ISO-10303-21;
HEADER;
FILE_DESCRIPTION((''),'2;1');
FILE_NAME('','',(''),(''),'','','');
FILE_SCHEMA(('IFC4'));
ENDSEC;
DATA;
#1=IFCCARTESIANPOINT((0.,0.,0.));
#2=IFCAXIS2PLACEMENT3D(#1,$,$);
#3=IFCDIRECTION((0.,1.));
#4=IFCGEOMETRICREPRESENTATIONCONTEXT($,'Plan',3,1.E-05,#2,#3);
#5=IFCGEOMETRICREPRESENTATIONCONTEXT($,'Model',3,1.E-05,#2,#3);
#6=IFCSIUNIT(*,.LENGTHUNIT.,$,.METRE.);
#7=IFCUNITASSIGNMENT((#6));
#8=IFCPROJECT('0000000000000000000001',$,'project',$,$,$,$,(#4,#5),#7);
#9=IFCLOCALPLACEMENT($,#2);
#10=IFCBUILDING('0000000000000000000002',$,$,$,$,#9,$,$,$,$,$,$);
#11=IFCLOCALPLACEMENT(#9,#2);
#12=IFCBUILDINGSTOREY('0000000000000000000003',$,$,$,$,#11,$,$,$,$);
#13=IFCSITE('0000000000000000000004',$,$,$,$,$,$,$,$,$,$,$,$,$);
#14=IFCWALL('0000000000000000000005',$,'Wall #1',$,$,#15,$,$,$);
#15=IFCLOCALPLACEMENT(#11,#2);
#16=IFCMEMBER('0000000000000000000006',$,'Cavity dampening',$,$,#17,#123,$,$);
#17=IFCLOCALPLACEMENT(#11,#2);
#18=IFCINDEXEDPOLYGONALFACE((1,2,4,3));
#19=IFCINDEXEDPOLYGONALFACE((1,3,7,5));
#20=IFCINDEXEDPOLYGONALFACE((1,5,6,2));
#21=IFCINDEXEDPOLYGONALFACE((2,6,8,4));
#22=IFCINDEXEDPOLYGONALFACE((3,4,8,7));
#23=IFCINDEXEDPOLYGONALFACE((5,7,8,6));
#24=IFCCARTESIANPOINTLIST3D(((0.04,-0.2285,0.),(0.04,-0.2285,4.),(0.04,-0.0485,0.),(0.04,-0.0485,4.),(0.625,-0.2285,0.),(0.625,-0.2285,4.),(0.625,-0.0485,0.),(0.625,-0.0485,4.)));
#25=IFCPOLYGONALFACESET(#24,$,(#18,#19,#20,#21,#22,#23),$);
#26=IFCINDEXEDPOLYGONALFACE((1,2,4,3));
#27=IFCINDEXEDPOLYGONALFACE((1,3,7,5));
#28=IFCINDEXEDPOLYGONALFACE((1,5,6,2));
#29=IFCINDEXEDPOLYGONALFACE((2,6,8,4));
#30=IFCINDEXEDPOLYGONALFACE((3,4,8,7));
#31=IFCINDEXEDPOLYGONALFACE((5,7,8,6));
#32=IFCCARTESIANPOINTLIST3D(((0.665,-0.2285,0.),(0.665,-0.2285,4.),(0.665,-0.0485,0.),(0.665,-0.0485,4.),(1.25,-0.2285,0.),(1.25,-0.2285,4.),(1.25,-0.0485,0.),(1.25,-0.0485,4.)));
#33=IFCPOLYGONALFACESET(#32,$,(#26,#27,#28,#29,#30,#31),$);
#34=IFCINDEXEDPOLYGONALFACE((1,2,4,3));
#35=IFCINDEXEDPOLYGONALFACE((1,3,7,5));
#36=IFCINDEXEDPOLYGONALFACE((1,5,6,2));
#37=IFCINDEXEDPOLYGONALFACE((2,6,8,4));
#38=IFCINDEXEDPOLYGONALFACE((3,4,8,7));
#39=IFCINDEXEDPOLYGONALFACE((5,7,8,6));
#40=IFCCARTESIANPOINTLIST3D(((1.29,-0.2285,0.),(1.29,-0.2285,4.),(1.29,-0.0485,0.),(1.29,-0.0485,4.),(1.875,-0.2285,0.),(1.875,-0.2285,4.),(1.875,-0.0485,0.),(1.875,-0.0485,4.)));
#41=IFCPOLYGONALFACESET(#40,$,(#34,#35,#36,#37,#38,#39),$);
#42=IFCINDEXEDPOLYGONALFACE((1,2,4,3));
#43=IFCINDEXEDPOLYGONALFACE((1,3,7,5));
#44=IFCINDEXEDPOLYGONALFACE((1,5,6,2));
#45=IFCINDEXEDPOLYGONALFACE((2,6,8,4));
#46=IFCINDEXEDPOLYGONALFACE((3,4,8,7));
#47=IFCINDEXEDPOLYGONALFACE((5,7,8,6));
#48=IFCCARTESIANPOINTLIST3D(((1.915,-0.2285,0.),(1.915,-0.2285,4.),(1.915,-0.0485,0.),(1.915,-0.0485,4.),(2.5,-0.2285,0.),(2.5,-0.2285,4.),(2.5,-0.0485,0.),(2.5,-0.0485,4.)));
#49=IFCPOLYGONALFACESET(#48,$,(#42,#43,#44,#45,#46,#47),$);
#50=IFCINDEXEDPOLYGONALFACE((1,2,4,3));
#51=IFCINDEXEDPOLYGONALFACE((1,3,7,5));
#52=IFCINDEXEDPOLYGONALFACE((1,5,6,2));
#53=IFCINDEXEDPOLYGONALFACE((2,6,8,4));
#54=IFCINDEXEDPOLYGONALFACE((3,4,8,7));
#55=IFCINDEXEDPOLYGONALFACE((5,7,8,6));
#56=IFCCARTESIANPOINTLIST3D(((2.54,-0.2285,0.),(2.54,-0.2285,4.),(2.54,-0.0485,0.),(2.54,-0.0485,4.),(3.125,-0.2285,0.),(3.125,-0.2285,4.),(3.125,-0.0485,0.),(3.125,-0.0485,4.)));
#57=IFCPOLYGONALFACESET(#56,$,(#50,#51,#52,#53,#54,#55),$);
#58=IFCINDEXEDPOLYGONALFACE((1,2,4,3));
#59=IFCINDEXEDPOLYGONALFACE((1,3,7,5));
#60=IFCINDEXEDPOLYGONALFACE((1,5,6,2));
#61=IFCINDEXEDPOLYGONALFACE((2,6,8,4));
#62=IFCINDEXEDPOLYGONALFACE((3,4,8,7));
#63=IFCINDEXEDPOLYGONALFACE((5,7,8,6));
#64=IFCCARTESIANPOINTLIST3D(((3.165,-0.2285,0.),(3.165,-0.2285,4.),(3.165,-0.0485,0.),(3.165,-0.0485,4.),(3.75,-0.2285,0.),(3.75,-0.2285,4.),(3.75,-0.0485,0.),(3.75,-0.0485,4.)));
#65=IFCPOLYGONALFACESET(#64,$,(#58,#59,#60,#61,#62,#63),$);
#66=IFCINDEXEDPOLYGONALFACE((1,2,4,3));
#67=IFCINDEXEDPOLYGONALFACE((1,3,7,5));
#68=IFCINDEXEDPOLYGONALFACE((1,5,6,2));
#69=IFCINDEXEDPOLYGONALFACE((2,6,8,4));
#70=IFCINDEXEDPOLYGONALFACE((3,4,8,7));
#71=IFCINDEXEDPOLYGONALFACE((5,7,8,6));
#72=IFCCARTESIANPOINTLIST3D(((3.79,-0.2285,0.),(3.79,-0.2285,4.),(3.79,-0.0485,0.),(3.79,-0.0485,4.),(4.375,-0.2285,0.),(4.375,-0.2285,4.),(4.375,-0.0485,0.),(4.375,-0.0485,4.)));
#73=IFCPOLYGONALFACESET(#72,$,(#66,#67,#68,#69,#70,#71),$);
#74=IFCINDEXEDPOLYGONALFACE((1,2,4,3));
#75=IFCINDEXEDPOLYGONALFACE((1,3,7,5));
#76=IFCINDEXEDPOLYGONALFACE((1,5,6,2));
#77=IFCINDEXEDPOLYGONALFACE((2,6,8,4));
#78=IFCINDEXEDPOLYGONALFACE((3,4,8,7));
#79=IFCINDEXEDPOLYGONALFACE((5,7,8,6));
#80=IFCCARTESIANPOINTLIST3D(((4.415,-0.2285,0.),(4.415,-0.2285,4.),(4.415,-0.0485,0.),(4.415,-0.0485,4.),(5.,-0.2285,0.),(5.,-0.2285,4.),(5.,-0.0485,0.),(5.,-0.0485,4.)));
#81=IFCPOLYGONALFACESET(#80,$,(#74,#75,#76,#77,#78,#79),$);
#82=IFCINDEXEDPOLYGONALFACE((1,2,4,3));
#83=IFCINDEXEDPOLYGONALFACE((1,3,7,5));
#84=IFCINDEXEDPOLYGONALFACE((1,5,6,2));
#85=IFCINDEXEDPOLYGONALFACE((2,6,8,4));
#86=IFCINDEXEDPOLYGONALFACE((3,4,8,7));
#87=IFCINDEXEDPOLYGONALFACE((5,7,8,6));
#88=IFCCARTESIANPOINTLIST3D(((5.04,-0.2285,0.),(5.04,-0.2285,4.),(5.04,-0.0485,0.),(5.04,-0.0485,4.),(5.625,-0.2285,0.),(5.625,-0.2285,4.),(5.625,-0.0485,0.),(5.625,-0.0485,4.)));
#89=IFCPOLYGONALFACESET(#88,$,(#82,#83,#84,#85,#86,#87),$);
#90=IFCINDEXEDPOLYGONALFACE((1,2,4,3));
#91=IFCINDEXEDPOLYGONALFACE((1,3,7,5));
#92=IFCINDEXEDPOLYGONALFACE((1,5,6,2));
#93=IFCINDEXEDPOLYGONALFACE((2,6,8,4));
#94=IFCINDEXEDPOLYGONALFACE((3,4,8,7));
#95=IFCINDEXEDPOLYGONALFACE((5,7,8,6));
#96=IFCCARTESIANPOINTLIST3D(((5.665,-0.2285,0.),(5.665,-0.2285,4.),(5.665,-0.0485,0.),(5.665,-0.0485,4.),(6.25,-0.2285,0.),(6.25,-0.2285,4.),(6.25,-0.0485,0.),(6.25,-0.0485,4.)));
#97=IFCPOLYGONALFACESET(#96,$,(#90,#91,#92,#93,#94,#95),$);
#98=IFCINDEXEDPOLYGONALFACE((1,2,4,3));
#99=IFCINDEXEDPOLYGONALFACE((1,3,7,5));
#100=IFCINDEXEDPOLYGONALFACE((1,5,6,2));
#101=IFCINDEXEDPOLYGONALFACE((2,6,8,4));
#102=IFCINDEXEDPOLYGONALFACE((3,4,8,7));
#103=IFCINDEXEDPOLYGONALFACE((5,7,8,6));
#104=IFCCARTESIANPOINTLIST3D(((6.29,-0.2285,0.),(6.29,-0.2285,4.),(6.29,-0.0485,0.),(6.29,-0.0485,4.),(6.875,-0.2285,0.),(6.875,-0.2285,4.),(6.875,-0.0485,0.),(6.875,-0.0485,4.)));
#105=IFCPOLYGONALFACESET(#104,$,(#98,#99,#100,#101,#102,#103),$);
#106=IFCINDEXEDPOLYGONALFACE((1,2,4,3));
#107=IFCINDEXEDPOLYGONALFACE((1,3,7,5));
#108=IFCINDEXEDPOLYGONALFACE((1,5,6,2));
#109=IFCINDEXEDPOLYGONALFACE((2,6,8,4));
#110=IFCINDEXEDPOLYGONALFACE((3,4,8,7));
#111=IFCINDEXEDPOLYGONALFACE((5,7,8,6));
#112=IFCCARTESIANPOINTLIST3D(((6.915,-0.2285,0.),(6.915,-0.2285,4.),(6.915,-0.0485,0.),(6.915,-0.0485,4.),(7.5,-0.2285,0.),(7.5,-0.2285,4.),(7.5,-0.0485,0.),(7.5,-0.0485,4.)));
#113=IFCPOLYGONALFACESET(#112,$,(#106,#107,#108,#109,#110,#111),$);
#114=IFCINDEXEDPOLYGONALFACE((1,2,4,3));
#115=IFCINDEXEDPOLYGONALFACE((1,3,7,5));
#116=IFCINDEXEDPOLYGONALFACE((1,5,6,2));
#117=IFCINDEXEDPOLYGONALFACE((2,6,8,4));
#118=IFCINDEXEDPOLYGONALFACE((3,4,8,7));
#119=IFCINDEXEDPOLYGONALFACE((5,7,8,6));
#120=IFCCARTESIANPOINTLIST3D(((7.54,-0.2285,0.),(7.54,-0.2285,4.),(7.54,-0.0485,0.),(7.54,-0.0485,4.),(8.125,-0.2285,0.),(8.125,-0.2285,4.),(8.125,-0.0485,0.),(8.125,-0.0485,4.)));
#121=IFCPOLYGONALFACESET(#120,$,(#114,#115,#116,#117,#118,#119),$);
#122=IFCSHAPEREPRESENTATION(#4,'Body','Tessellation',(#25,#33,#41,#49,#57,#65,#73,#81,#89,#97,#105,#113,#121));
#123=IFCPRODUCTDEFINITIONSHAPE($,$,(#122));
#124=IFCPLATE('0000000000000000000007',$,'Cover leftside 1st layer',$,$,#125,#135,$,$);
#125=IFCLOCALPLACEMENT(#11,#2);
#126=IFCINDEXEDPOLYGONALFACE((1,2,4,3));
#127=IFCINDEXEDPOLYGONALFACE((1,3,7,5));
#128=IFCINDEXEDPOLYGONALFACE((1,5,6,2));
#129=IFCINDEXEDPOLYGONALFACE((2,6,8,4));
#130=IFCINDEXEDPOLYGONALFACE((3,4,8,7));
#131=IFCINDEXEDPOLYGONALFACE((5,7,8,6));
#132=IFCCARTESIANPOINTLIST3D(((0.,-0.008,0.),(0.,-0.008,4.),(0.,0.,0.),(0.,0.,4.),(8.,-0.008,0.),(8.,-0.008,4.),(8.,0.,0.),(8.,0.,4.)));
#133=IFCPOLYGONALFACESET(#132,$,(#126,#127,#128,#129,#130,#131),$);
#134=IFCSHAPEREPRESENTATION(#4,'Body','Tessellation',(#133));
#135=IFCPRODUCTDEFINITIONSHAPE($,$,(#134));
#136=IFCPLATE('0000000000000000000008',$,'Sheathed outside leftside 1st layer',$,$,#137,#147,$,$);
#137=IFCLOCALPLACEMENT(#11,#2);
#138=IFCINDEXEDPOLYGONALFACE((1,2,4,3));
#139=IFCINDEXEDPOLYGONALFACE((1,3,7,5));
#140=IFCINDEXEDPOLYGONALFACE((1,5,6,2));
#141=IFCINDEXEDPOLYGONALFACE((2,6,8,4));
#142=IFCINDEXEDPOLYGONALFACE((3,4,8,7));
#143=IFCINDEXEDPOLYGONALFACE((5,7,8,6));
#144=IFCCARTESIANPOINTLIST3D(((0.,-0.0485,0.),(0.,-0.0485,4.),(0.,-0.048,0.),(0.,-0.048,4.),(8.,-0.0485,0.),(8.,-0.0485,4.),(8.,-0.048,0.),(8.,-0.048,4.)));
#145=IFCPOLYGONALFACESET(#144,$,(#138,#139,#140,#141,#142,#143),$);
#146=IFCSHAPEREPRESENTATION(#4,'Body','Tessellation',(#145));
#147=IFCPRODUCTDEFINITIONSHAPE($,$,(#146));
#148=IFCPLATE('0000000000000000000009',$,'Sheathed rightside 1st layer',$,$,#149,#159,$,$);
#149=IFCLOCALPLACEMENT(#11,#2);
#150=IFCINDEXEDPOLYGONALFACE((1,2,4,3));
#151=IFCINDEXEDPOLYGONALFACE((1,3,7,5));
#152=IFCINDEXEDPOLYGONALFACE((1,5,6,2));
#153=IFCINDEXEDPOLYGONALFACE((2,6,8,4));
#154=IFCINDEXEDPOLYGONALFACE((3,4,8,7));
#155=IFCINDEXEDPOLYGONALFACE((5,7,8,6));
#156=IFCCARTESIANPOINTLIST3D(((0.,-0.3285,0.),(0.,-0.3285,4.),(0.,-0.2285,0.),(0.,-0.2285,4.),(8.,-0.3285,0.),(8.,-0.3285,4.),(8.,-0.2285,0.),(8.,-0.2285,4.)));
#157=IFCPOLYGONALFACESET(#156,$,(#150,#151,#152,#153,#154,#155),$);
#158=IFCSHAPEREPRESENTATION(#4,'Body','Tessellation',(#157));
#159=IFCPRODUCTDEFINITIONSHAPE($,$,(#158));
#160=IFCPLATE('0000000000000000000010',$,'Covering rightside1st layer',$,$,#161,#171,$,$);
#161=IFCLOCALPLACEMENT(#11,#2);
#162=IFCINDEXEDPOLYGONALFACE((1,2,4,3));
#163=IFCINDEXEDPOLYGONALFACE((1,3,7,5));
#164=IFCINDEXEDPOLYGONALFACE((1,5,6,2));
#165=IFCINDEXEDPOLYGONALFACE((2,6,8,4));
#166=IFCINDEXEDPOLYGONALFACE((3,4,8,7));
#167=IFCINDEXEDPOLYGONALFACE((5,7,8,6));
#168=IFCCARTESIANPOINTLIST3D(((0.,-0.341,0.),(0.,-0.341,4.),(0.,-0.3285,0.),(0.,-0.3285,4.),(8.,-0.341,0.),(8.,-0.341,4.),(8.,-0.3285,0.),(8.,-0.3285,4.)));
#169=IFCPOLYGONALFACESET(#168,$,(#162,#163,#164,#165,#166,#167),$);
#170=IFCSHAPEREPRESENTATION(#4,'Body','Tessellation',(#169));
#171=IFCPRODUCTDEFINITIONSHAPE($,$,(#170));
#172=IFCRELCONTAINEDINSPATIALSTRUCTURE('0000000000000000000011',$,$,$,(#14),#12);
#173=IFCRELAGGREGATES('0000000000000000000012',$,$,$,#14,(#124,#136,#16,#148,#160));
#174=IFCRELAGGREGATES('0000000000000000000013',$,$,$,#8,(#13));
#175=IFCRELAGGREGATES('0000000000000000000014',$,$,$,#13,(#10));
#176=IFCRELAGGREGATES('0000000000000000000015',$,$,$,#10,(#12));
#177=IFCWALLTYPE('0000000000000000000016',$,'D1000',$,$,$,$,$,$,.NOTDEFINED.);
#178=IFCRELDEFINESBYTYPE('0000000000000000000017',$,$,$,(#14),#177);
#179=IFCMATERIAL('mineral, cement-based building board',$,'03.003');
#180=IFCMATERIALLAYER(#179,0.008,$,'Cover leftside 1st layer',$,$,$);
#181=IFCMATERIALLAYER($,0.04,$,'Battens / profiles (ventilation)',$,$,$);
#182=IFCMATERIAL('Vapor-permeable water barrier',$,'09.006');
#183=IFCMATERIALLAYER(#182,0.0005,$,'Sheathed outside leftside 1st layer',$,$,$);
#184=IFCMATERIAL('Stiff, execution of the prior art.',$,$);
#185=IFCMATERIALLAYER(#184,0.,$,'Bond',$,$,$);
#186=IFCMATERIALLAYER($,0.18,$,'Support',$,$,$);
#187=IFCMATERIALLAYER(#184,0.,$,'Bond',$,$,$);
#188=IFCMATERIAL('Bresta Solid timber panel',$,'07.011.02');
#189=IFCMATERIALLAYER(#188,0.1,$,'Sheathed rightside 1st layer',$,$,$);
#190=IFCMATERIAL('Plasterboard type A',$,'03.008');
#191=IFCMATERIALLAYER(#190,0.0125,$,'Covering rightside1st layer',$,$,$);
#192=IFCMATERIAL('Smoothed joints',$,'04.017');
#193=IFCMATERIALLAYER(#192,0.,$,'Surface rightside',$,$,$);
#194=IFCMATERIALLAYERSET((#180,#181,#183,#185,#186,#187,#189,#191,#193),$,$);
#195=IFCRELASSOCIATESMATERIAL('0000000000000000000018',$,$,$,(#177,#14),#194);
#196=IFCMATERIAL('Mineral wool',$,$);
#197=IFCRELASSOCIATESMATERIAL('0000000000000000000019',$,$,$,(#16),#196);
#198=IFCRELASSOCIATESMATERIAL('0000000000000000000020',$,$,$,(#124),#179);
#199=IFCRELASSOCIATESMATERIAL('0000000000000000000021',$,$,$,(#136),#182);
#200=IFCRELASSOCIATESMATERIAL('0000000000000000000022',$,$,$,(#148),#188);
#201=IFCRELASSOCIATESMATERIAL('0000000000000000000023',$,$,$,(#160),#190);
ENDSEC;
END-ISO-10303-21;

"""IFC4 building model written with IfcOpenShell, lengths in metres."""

from ifc_helpers import new_model, si_unit, direction, frame, frame_2d, origin, origin_with_axes, place, context, project, spatial, rectangle, extrude, material, layer, layer_set, type_object, element, aggregate, save


model = new_model("IFC4")

# Units and contexts
plan_context = context("Plan", 3, precision=1e-05, world=origin(), true_north=direction((0.0, 1.0)))
model_context = context("Model", 3, precision=1e-05, world=origin(), true_north=direction((0.0, 1.0)))
ifc_project = project(units=[si_unit("LENGTHUNIT", "METRE")], contexts=[plan_context, model_context])

# Site, building, storey
site = spatial("IfcSite", under=ifc_project)
building_placement = place(None, origin())
building = spatial("IfcBuilding", under=site, at=building_placement)
storey_placement = place(building_placement, origin())
storey = spatial("IfcBuildingStorey", under=building, at=storey_placement)

# Wall, member, plates
ifc_material_1 = material(Name="mineral, cement-based building board", Category="03.003")
ifc_layer_1 = layer(ifc_material_1, 0.008, Name="Cover leftside 1st layer")
ifc_layer_2 = layer(None, 0.04, Name="Battens / profiles (ventilation)")
ifc_material_2 = material(Name="Vapor-permeable water barrier", Category="09.006")
ifc_layer_3 = layer(ifc_material_2, 0.0005, Name="Sheathed outside leftside 1st layer")
ifc_material_3 = material(Name="Stiff, execution of the prior art.")
ifc_layer_4 = layer(ifc_material_3, 0.0, Name="Bond")
ifc_layer_5 = layer(None, 0.18, Name="Support")
ifc_layer_6 = layer(ifc_material_3, 0.0, Name="Bond")
ifc_material_4 = material(Name="Bresta Solid timber panel", Category="07.011.02")
ifc_layer_7 = layer(ifc_material_4, 0.1, Name="Sheathed rightside 1st layer")
ifc_material_5 = material(Name="Plasterboard type A", Category="03.008")
ifc_layer_8 = layer(ifc_material_5, 0.0125, Name="Covering rightside1st layer")
ifc_material_6 = material(Name="Smoothed joints", Category="04.017")
ifc_layer_9 = layer(ifc_material_6, 0.0, Name="Surface rightside")
ifc_layer_set = layer_set([ifc_layer_1, ifc_layer_2, ifc_layer_3, ifc_layer_4, ifc_layer_5, ifc_layer_6, ifc_layer_7, ifc_layer_8, ifc_layer_9])
wall_type = type_object("IfcWallType", Name="D1000", PredefinedType="NOTDEFINED", material=ifc_layer_set)
wall_placement = place(None, frame((0.0, 0.0, 0.0), z_axis=(0.0, -1.0, 0.0), x_axis=(1.0, 0.0, 0.0)))
wall = element("IfcWall", 1, at=wall_placement, inside=storey, type_object=wall_type, material=ifc_layer_set, Name="Wall #1")
ifc_material_7 = material(Name="Mineral wool")
member_1_placement = place(wall_placement, origin())
member_1 = element("IfcMember", 2, at=member_1_placement, material=ifc_material_7, Name="Cavity dampening", context=plan_context, shape_type="SweptSolid", body=[
    extrude(rectangle(XDim=0.585, YDim=0.18, at=frame_2d((0.2925, 0.09), x_axis=(1.0, 0.0))), frame((0.04, 4.0, 0.0485), z_axis=(0.0, -1.0, 0.0), x_axis=(1.0, 0.0, 0.0)), (0.0, 0.0, 1.0), 4.0),
    extrude(rectangle(XDim=0.585, YDim=0.18, at=frame_2d((0.2925, 0.09), x_axis=(1.0, 0.0))), frame((0.665, 4.0, 0.0485), z_axis=(0.0, -1.0, 0.0), x_axis=(1.0, 0.0, 0.0)), (0.0, 0.0, 1.0), 4.0),
    extrude(rectangle(XDim=0.585, YDim=0.18, at=frame_2d((0.2925, 0.09), x_axis=(1.0, 0.0))), frame((1.29, 4.0, 0.0485), z_axis=(0.0, -1.0, 0.0), x_axis=(1.0, 0.0, 0.0)), (0.0, 0.0, 1.0), 4.0),
    extrude(rectangle(XDim=0.585, YDim=0.18, at=frame_2d((0.2925, 0.09), x_axis=(1.0, 0.0))), frame((1.915, 4.0, 0.0485), z_axis=(0.0, -1.0, 0.0), x_axis=(1.0, 0.0, 0.0)), (0.0, 0.0, 1.0), 4.0),
    extrude(rectangle(XDim=0.585, YDim=0.18, at=frame_2d((0.2925, 0.09), x_axis=(1.0, 0.0))), frame((2.54, 4.0, 0.0485), z_axis=(0.0, -1.0, 0.0), x_axis=(1.0, 0.0, 0.0)), (0.0, 0.0, 1.0), 4.0),
    extrude(rectangle(XDim=0.585, YDim=0.18, at=frame_2d((0.2925, 0.09), x_axis=(1.0, 0.0))), frame((3.165, 4.0, 0.0485), z_axis=(0.0, -1.0, 0.0), x_axis=(1.0, 0.0, 0.0)), (0.0, 0.0, 1.0), 4.0),
    extrude(rectangle(XDim=0.585, YDim=0.18, at=frame_2d((0.2925, 0.09), x_axis=(1.0, 0.0))), frame((3.79, 4.0, 0.0485), z_axis=(0.0, -1.0, 0.0), x_axis=(1.0, 0.0, 0.0)), (0.0, 0.0, 1.0), 4.0),
    extrude(rectangle(XDim=0.585, YDim=0.18, at=frame_2d((0.2925, 0.09), x_axis=(1.0, 0.0))), frame((4.415, 4.0, 0.0485), z_axis=(0.0, -1.0, 0.0), x_axis=(1.0, 0.0, 0.0)), (0.0, 0.0, 1.0), 4.0),
    extrude(rectangle(XDim=0.585, YDim=0.18, at=frame_2d((0.2925, 0.09), x_axis=(1.0, 0.0))), frame((5.04, 4.0, 0.0485), z_axis=(0.0, -1.0, 0.0), x_axis=(1.0, 0.0, 0.0)), (0.0, 0.0, 1.0), 4.0),
    extrude(rectangle(XDim=0.585, YDim=0.18, at=frame_2d((0.2925, 0.09), x_axis=(1.0, 0.0))), frame((5.665, 4.0, 0.0485), z_axis=(0.0, -1.0, 0.0), x_axis=(1.0, 0.0, 0.0)), (0.0, 0.0, 1.0), 4.0),
    extrude(rectangle(XDim=0.585, YDim=0.18, at=frame_2d((0.2925, 0.09), x_axis=(1.0, 0.0))), frame((6.29, 4.0, 0.0485), z_axis=(0.0, -1.0, 0.0), x_axis=(1.0, 0.0, 0.0)), (0.0, 0.0, 1.0), 4.0),
    extrude(rectangle(XDim=0.585, YDim=0.18, at=frame_2d((0.2925, 0.09), x_axis=(1.0, 0.0))), frame((6.915, 4.0, 0.0485), z_axis=(0.0, -1.0, 0.0), x_axis=(1.0, 0.0, 0.0)), (0.0, 0.0, 1.0), 4.0),
    extrude(rectangle(XDim=0.585, YDim=0.18, at=frame_2d((0.2925, 0.09), x_axis=(1.0, 0.0))), frame((7.54, 4.0, 0.0485), z_axis=(0.0, -1.0, 0.0), x_axis=(1.0, 0.0, 0.0)), (0.0, 0.0, 1.0), 4.0),
])
plate_1_placement = place(wall_placement, origin())
plate_1 = element("IfcPlate", 3, at=plate_1_placement, material=ifc_material_1, Name="Cover leftside 1st layer", context=plan_context, shape_type="SweptSolid", body=[
    extrude(rectangle(XDim=8.0, YDim=4.0, at=frame_2d((4.0, 2.0), x_axis=(1.0, 0.0))), origin_with_axes(), (0.0, 0.0, 1.0), 0.008),
])
plate_2_placement = place(wall_placement, origin())
plate_2 = element("IfcPlate", 4, at=plate_2_placement, material=ifc_material_2, Name="Sheathed outside leftside 1st layer", context=plan_context, shape_type="SweptSolid", body=[
    extrude(rectangle(XDim=8.0, YDim=4.0, at=frame_2d((4.0, 2.0), x_axis=(1.0, 0.0))), frame((0.0, 0.0, 0.048), z_axis=(0.0, 0.0, 1.0), x_axis=(1.0, 0.0, 0.0)), (0.0, 0.0, 1.0), 0.0005),
])
plate_3_placement = place(wall_placement, origin())
plate_3 = element("IfcPlate", 5, at=plate_3_placement, material=ifc_material_4, Name="Sheathed rightside 1st layer", context=plan_context, shape_type="SweptSolid", body=[
    extrude(rectangle(XDim=8.0, YDim=4.0, at=frame_2d((4.0, 2.0), x_axis=(1.0, 0.0))), frame((0.0, 0.0, 0.2285), z_axis=(0.0, 0.0, 1.0), x_axis=(1.0, 0.0, 0.0)), (0.0, 0.0, 1.0), 0.1),
])
plate_4_placement = place(wall_placement, origin())
plate_4 = element("IfcPlate", 6, at=plate_4_placement, material=ifc_material_5, Name="Covering rightside1st layer", context=plan_context, shape_type="SweptSolid", body=[
    extrude(rectangle(XDim=8.0, YDim=4.0, at=frame_2d((4.0, 2.0), x_axis=(1.0, 0.0))), frame((0.0, 0.0, 0.3285), z_axis=(0.0, 0.0, 1.0), x_axis=(1.0, 0.0, 0.0)), (0.0, 0.0, 1.0), 0.0125),
])
aggregate(wall, [plate_1, plate_2, member_1, plate_3, plate_4])

save(model, "model.ifc")
